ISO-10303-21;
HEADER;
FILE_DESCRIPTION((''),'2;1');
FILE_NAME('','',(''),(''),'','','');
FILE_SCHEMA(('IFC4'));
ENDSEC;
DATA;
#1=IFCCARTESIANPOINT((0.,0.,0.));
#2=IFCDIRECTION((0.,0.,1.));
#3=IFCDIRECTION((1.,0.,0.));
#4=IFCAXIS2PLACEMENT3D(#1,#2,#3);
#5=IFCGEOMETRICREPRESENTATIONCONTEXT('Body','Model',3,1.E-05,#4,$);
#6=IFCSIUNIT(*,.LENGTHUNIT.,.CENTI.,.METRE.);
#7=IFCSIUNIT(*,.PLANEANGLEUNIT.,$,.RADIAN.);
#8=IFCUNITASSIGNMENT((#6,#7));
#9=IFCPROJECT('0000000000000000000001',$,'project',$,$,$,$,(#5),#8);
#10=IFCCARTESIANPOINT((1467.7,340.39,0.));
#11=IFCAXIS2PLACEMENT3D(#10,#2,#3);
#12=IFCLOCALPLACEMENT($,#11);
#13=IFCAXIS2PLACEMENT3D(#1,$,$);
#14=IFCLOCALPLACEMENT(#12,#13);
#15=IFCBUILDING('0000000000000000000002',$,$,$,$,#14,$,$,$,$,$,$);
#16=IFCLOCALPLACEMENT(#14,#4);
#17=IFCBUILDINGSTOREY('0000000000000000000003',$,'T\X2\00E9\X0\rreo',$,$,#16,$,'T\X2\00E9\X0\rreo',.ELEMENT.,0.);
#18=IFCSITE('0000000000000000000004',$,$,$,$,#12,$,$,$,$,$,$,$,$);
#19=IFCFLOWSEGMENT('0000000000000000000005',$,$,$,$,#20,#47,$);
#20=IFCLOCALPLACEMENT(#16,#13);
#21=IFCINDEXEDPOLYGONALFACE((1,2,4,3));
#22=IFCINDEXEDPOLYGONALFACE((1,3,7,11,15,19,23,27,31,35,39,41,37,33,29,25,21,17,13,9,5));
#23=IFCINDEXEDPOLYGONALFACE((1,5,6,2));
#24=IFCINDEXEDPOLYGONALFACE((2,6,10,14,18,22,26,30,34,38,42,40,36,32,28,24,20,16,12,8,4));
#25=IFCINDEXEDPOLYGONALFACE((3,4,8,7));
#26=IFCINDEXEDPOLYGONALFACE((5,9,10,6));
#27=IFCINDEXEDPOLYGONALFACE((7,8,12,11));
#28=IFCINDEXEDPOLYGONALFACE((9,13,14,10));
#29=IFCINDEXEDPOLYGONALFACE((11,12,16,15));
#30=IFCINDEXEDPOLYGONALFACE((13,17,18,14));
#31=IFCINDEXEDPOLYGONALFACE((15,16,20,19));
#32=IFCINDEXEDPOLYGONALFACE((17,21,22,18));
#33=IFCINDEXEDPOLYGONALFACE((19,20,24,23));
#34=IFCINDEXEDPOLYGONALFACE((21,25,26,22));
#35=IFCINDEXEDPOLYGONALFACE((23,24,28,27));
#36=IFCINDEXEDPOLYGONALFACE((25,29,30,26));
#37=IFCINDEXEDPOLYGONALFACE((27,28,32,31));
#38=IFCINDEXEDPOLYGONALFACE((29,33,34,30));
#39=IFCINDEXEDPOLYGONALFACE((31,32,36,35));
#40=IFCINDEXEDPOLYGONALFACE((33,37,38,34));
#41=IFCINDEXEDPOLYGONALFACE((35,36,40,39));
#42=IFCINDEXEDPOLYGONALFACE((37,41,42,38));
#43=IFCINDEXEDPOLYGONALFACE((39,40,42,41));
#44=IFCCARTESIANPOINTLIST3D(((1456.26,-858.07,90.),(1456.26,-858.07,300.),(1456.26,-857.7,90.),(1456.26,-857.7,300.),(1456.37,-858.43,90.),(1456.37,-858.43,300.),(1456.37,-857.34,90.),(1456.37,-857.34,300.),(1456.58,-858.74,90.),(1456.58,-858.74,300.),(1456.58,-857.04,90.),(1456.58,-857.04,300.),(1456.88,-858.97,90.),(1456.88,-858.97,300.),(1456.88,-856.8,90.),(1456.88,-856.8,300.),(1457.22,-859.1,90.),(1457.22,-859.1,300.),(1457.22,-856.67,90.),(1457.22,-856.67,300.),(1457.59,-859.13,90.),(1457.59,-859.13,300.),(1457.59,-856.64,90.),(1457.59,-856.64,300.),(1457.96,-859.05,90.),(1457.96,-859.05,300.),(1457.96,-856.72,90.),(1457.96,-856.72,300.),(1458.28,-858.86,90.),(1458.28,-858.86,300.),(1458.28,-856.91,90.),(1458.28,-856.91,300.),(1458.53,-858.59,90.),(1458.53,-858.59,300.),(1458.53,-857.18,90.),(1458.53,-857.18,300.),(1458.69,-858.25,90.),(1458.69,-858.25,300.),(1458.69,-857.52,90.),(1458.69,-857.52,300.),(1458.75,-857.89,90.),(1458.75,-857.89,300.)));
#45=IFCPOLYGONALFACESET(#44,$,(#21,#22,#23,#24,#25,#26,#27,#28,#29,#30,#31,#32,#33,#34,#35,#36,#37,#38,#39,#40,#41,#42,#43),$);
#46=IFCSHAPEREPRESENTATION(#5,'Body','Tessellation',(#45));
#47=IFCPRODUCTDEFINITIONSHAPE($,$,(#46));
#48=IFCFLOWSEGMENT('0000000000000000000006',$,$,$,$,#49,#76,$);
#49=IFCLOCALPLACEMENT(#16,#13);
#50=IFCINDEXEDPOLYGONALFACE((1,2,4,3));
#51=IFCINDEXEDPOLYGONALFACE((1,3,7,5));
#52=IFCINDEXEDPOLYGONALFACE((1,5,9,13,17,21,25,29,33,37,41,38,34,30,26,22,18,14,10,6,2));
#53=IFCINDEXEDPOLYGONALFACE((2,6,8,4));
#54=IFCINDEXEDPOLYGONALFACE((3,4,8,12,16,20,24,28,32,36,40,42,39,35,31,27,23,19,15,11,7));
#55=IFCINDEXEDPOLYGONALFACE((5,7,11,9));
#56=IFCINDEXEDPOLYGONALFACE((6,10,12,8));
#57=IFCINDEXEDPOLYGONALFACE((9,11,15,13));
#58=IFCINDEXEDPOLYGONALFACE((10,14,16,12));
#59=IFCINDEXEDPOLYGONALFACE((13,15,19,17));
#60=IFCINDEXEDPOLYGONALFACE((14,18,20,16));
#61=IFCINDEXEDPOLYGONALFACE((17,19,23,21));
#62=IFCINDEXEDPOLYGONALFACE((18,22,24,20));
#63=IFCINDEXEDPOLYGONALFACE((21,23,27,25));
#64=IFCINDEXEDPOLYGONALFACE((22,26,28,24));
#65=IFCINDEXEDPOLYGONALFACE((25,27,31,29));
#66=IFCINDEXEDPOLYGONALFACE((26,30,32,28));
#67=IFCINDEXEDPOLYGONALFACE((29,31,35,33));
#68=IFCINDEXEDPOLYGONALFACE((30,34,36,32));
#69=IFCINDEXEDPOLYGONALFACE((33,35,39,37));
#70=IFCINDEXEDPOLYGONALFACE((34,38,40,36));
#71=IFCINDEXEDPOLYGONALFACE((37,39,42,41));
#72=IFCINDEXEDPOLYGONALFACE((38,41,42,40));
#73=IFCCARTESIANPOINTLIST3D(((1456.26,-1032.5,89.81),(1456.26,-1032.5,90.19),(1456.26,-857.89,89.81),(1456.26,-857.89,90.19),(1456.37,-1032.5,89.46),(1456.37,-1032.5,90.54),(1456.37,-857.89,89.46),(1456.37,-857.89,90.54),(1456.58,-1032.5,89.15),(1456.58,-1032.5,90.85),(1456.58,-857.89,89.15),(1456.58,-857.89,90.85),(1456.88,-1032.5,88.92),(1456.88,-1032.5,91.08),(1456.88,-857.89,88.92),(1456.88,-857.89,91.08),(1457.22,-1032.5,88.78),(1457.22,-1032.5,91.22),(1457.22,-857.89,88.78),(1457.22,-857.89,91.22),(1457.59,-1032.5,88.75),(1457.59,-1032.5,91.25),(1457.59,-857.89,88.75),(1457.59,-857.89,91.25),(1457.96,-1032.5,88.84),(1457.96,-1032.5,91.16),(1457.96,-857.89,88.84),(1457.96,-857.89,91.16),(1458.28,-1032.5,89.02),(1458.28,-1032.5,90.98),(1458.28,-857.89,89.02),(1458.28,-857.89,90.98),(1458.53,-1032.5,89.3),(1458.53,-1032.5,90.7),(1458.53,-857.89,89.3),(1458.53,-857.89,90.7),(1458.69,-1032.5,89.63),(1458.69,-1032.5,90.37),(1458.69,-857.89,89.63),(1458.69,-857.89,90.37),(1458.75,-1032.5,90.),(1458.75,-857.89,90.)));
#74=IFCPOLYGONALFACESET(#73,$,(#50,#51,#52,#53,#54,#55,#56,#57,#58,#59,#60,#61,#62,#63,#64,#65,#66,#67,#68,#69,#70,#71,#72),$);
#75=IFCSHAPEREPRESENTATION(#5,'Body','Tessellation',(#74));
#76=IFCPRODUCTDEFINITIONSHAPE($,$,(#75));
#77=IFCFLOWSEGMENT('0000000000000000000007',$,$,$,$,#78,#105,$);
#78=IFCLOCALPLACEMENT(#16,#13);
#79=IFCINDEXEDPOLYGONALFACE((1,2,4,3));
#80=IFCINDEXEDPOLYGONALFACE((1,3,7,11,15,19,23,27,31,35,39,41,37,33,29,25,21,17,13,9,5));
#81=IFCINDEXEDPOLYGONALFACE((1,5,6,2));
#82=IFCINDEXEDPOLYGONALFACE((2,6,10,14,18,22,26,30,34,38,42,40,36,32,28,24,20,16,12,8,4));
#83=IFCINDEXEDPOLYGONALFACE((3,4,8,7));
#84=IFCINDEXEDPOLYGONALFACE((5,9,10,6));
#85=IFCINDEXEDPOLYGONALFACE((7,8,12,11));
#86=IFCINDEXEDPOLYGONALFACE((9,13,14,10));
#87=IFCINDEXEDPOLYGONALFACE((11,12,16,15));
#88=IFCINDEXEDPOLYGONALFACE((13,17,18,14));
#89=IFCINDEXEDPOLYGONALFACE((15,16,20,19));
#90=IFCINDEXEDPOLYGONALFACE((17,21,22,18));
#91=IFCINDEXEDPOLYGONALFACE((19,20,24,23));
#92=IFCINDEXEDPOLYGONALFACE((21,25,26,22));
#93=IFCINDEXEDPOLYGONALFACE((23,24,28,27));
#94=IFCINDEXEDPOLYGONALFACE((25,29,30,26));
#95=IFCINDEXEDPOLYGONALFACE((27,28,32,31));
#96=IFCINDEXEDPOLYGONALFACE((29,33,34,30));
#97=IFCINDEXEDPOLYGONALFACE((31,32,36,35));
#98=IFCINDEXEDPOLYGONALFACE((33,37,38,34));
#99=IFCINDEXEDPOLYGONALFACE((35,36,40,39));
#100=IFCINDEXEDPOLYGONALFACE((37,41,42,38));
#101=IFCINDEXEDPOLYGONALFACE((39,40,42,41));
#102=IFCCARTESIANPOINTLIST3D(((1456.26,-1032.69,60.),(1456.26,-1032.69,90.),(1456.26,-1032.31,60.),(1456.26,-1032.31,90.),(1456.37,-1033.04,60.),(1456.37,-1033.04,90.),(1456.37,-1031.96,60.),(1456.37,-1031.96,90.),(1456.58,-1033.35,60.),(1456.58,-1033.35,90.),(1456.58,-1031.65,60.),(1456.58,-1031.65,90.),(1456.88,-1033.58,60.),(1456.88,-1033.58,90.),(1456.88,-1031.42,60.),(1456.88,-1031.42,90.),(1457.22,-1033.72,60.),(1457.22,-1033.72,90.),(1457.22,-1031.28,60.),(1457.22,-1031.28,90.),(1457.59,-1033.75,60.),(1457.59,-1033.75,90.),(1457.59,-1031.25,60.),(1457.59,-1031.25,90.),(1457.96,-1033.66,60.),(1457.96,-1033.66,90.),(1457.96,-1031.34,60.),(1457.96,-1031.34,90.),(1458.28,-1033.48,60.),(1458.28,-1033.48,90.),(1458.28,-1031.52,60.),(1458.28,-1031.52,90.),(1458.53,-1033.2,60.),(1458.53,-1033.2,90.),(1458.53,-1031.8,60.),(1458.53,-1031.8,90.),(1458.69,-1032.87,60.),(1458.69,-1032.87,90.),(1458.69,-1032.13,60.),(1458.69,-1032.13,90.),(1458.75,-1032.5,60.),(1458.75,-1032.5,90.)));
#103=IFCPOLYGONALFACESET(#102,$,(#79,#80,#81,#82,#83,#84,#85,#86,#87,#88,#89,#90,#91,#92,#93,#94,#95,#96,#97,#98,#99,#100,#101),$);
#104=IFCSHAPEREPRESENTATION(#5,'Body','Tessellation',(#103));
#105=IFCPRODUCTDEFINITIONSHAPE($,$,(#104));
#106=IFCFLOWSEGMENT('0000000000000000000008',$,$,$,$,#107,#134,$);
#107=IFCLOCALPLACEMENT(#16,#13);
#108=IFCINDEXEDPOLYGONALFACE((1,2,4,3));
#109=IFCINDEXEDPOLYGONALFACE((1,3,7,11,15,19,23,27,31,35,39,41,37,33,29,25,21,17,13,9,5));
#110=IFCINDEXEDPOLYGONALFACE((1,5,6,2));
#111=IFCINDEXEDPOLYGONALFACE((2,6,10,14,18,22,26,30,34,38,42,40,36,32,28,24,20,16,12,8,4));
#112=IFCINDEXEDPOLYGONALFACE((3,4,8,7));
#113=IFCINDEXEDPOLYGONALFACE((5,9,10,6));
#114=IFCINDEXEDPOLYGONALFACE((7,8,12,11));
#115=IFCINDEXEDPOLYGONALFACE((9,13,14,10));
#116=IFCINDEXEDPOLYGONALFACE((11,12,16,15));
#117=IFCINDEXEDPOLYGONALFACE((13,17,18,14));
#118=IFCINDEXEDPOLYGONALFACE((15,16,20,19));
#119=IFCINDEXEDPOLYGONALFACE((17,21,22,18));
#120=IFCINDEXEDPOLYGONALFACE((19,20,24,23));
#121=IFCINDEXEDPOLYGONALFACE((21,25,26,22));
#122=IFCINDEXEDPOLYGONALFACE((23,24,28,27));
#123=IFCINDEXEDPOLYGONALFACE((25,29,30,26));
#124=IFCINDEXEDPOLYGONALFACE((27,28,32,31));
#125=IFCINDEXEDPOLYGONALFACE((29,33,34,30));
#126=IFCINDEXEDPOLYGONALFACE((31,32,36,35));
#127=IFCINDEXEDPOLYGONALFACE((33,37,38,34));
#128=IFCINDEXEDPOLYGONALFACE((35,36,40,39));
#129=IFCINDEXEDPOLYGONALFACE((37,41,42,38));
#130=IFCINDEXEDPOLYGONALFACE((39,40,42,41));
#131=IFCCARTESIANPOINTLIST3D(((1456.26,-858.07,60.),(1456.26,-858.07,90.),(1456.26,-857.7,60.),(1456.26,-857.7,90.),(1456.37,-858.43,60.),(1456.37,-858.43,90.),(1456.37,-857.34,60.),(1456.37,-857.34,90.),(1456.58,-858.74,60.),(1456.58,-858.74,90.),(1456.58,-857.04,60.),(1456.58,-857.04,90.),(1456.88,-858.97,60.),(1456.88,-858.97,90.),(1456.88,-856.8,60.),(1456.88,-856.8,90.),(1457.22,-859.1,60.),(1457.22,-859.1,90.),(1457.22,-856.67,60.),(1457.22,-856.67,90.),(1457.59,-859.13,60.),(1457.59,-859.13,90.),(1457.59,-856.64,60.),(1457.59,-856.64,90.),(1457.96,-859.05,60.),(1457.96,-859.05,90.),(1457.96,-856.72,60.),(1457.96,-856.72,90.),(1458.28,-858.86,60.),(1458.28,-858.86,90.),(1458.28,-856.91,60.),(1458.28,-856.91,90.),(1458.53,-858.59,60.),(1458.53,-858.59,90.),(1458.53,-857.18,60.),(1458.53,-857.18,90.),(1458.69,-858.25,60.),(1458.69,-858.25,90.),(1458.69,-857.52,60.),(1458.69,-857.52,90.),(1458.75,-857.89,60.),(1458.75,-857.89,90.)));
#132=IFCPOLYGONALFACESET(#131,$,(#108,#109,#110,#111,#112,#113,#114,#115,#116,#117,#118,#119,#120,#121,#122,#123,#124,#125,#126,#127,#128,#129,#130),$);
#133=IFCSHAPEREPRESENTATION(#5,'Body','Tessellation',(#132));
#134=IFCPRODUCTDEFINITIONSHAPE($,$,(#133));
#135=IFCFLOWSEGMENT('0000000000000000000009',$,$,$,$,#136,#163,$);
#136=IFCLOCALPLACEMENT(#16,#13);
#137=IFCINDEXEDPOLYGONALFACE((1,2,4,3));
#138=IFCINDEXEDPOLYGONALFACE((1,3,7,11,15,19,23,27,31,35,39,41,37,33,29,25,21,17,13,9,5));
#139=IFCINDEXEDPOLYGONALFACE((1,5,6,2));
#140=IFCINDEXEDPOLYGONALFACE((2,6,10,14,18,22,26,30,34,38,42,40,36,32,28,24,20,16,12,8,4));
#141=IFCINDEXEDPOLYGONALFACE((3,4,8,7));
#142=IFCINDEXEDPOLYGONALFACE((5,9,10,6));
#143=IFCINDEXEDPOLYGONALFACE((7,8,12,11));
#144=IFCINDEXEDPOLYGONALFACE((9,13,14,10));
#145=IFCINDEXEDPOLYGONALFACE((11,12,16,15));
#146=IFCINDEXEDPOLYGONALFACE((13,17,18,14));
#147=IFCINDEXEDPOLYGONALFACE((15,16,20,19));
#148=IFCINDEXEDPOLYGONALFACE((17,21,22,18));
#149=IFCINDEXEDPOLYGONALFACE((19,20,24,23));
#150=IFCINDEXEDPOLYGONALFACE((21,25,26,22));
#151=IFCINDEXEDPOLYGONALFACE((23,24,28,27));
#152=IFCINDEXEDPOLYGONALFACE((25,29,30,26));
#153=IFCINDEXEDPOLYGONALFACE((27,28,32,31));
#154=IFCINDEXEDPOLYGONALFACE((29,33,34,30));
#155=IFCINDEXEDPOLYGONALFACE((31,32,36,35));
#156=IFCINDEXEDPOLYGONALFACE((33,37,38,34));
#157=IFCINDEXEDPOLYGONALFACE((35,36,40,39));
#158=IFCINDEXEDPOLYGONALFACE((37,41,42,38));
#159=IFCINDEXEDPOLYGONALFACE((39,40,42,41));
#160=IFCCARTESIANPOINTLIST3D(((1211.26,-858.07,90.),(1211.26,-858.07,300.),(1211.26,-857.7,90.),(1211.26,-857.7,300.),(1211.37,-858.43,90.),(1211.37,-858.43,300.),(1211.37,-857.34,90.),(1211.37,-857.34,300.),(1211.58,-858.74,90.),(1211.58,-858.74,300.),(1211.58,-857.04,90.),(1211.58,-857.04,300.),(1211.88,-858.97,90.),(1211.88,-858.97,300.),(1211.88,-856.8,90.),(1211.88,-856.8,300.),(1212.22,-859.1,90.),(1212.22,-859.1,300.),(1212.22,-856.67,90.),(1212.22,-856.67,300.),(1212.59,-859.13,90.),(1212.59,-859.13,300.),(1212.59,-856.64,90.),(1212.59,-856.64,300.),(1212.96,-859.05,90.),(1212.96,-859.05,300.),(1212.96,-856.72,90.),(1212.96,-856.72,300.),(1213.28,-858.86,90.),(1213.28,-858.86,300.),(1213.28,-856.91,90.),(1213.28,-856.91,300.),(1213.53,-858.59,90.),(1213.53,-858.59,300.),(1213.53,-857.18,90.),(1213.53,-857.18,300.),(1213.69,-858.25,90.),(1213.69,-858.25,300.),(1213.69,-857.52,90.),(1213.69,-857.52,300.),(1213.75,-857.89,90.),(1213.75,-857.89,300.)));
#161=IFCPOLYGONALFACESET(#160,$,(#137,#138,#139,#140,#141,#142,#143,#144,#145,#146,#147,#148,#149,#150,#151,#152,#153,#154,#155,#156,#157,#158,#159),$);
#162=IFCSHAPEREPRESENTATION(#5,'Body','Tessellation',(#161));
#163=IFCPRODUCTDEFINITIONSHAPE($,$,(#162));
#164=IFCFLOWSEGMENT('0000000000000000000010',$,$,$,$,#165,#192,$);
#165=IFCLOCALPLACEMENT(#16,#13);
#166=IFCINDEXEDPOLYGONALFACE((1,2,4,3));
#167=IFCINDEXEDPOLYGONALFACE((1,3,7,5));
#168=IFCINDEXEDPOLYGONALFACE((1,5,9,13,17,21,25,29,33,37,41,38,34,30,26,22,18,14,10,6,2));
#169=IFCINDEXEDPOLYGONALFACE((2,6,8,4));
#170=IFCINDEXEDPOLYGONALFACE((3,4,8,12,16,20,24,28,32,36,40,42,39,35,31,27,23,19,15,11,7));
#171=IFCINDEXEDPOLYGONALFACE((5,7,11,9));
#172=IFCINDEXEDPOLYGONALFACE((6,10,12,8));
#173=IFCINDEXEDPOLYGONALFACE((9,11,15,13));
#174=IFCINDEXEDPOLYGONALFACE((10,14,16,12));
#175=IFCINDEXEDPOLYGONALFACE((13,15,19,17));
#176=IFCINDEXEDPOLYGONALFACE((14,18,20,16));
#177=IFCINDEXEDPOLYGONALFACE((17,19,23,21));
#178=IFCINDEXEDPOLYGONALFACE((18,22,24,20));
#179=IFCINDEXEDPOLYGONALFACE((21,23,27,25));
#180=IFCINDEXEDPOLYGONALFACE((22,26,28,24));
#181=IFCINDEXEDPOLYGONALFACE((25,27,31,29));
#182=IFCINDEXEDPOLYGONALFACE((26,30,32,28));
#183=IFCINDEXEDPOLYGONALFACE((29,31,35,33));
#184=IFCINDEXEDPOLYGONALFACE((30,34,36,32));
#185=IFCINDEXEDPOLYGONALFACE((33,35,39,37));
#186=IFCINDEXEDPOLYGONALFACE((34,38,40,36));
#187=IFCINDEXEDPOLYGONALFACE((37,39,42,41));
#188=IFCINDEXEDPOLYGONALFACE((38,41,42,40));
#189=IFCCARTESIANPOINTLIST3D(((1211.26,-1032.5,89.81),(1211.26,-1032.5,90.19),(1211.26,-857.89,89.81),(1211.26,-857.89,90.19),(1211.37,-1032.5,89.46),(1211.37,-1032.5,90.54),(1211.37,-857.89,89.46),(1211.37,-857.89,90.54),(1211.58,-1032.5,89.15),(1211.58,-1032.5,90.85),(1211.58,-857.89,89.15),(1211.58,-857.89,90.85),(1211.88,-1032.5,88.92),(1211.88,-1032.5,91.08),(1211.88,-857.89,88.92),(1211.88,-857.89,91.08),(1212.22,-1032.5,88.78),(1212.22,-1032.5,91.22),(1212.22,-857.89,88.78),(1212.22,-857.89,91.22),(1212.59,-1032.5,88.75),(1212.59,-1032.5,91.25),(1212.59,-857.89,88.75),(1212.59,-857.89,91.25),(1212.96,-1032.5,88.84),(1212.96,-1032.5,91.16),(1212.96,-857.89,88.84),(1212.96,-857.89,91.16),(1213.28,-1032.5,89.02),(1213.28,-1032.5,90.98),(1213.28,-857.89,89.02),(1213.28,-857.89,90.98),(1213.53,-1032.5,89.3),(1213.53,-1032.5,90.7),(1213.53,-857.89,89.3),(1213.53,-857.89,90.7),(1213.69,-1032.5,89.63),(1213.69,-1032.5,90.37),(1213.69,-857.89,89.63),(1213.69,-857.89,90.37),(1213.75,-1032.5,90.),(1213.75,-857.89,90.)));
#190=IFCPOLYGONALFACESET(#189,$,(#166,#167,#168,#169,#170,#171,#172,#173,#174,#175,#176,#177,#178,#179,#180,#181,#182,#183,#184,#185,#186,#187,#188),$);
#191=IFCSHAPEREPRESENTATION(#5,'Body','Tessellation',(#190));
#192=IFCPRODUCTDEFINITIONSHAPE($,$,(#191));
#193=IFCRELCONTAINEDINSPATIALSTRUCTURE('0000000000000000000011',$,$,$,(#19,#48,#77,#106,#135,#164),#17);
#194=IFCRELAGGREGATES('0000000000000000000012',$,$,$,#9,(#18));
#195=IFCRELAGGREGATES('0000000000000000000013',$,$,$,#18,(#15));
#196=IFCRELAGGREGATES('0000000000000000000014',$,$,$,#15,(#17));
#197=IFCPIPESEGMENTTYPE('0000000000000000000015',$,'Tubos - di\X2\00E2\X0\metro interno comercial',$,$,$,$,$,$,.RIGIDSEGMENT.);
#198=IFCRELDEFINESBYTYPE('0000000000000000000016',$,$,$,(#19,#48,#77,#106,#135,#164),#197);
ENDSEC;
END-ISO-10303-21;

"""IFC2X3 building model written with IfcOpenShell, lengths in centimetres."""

from ifc_helpers import new_model, si_unit, frame, origin, origin_with_axes, origin_2d_with_axis, place, context, project, spatial, circle, extrude, type_object, element, save


model = new_model("IFC2X3")

# Units and contexts
model_context = context("Model", 3, precision=1e-05, world=origin_with_axes(), identifier="Body")
ifc_project = project(units=[si_unit("LENGTHUNIT", "METRE", prefix="CENTI"), si_unit("PLANEANGLEUNIT", "RADIAN")], contexts=[model_context])

# Site, building, storey
site_placement = place(None, frame((1467.7, 340.39, 0.0), z_axis=(0.0, 0.0, 1.0), x_axis=(1.0, 0.0, 0.0)))
site = spatial("IfcSite", under=ifc_project, at=site_placement)
building_placement = place(site_placement, origin())
building = spatial("IfcBuilding", under=site, at=building_placement)
storey_placement = place(building_placement, origin_with_axes())
storey = spatial("IfcBuildingStorey", under=building, at=storey_placement, Name="Térreo", LongName="Térreo", CompositionType="ELEMENT", Elevation=0.0)

# Flow segments
pipe_segment_type_1 = type_object("IfcPipeSegmentType", Name="Tubos - diâmetro interno comercial", PredefinedType="RIGIDSEGMENT")
flow_segment_1_placement = place(storey_placement, frame((1457.5, -857.89, 300.0), z_axis=(0.0, 0.0, 1.0), x_axis=(1.0, 0.0, 0.0)))
element("IfcFlowSegment", 1, at=flow_segment_1_placement, inside=storey, type_object=pipe_segment_type_1, context=model_context, shape_type="SolidModel", body=[
    extrude(circle(Radius=1.25, at=origin_2d_with_axis()), frame((0.0, 0.0, 0.0), z_axis=(0.0, 0.0, -1.0), x_axis=(1.0, 0.0, 0.0)), (0.0, 0.0, 1.0), 210.0),
])
flow_segment_2_placement = place(storey_placement, frame((1457.5, -945.19, 91.25), z_axis=(0.0, 0.0, 1.0), x_axis=(1.0, 0.0, 0.0)))
element("IfcFlowSegment", 2, at=flow_segment_2_placement, inside=storey, type_object=pipe_segment_type_1, context=model_context, shape_type="SolidModel", body=[
    extrude(circle(Radius=1.25, at=origin_2d_with_axis()), frame((0.0, 87.31, -1.25), z_axis=(0.0, -1.0, 0.0), x_axis=(1.0, 0.0, 0.0)), (0.0, 0.0, 1.0), 174.61),
])
for number, where, z_axis, x_axis in (
    (3, (1457.5, -1032.5, 90.0), (0.0, 0.0, 1.0), (1.0, 0.0, 0.0)),
    (4, (1457.5, -857.89, 90.0), (0.0, 0.0, 1.0), (1.0, 0.0, 0.0)),
):
    element("IfcFlowSegment", number, at=place(storey_placement, frame(where, z_axis=z_axis, x_axis=x_axis)), inside=storey, type_object=pipe_segment_type_1, context=model_context, shape_type="SolidModel", body=[
        extrude(circle(Radius=1.25, at=origin_2d_with_axis()), frame((0.0, 0.0, 0.0), z_axis=(0.0, 0.0, -1.0), x_axis=(1.0, 0.0, 0.0)), (0.0, 0.0, 1.0), 30.0),
    ])
flow_segment_3_placement = place(storey_placement, frame((1212.5, -857.89, 300.0), z_axis=(0.0, 0.0, 1.0), x_axis=(1.0, 0.0, 0.0)))
element("IfcFlowSegment", 5, at=flow_segment_3_placement, inside=storey, type_object=pipe_segment_type_1, context=model_context, shape_type="SolidModel", body=[
    extrude(circle(Radius=1.25, at=origin_2d_with_axis()), frame((0.0, 0.0, 0.0), z_axis=(0.0, 0.0, -1.0), x_axis=(1.0, 0.0, 0.0)), (0.0, 0.0, 1.0), 210.0),
])
flow_segment_4_placement = place(storey_placement, frame((1212.5, -945.19, 91.25), z_axis=(0.0, 0.0, 1.0), x_axis=(1.0, 0.0, 0.0)))
element("IfcFlowSegment", 6, at=flow_segment_4_placement, inside=storey, type_object=pipe_segment_type_1, context=model_context, shape_type="SolidModel", body=[
    extrude(circle(Radius=1.25, at=origin_2d_with_axis()), frame((0.0, 87.31, -1.25), z_axis=(0.0, -1.0, 0.0), x_axis=(1.0, 0.0, 0.0)), (0.0, 0.0, 1.0), 174.61),
])

save(model, "model.ifc")
